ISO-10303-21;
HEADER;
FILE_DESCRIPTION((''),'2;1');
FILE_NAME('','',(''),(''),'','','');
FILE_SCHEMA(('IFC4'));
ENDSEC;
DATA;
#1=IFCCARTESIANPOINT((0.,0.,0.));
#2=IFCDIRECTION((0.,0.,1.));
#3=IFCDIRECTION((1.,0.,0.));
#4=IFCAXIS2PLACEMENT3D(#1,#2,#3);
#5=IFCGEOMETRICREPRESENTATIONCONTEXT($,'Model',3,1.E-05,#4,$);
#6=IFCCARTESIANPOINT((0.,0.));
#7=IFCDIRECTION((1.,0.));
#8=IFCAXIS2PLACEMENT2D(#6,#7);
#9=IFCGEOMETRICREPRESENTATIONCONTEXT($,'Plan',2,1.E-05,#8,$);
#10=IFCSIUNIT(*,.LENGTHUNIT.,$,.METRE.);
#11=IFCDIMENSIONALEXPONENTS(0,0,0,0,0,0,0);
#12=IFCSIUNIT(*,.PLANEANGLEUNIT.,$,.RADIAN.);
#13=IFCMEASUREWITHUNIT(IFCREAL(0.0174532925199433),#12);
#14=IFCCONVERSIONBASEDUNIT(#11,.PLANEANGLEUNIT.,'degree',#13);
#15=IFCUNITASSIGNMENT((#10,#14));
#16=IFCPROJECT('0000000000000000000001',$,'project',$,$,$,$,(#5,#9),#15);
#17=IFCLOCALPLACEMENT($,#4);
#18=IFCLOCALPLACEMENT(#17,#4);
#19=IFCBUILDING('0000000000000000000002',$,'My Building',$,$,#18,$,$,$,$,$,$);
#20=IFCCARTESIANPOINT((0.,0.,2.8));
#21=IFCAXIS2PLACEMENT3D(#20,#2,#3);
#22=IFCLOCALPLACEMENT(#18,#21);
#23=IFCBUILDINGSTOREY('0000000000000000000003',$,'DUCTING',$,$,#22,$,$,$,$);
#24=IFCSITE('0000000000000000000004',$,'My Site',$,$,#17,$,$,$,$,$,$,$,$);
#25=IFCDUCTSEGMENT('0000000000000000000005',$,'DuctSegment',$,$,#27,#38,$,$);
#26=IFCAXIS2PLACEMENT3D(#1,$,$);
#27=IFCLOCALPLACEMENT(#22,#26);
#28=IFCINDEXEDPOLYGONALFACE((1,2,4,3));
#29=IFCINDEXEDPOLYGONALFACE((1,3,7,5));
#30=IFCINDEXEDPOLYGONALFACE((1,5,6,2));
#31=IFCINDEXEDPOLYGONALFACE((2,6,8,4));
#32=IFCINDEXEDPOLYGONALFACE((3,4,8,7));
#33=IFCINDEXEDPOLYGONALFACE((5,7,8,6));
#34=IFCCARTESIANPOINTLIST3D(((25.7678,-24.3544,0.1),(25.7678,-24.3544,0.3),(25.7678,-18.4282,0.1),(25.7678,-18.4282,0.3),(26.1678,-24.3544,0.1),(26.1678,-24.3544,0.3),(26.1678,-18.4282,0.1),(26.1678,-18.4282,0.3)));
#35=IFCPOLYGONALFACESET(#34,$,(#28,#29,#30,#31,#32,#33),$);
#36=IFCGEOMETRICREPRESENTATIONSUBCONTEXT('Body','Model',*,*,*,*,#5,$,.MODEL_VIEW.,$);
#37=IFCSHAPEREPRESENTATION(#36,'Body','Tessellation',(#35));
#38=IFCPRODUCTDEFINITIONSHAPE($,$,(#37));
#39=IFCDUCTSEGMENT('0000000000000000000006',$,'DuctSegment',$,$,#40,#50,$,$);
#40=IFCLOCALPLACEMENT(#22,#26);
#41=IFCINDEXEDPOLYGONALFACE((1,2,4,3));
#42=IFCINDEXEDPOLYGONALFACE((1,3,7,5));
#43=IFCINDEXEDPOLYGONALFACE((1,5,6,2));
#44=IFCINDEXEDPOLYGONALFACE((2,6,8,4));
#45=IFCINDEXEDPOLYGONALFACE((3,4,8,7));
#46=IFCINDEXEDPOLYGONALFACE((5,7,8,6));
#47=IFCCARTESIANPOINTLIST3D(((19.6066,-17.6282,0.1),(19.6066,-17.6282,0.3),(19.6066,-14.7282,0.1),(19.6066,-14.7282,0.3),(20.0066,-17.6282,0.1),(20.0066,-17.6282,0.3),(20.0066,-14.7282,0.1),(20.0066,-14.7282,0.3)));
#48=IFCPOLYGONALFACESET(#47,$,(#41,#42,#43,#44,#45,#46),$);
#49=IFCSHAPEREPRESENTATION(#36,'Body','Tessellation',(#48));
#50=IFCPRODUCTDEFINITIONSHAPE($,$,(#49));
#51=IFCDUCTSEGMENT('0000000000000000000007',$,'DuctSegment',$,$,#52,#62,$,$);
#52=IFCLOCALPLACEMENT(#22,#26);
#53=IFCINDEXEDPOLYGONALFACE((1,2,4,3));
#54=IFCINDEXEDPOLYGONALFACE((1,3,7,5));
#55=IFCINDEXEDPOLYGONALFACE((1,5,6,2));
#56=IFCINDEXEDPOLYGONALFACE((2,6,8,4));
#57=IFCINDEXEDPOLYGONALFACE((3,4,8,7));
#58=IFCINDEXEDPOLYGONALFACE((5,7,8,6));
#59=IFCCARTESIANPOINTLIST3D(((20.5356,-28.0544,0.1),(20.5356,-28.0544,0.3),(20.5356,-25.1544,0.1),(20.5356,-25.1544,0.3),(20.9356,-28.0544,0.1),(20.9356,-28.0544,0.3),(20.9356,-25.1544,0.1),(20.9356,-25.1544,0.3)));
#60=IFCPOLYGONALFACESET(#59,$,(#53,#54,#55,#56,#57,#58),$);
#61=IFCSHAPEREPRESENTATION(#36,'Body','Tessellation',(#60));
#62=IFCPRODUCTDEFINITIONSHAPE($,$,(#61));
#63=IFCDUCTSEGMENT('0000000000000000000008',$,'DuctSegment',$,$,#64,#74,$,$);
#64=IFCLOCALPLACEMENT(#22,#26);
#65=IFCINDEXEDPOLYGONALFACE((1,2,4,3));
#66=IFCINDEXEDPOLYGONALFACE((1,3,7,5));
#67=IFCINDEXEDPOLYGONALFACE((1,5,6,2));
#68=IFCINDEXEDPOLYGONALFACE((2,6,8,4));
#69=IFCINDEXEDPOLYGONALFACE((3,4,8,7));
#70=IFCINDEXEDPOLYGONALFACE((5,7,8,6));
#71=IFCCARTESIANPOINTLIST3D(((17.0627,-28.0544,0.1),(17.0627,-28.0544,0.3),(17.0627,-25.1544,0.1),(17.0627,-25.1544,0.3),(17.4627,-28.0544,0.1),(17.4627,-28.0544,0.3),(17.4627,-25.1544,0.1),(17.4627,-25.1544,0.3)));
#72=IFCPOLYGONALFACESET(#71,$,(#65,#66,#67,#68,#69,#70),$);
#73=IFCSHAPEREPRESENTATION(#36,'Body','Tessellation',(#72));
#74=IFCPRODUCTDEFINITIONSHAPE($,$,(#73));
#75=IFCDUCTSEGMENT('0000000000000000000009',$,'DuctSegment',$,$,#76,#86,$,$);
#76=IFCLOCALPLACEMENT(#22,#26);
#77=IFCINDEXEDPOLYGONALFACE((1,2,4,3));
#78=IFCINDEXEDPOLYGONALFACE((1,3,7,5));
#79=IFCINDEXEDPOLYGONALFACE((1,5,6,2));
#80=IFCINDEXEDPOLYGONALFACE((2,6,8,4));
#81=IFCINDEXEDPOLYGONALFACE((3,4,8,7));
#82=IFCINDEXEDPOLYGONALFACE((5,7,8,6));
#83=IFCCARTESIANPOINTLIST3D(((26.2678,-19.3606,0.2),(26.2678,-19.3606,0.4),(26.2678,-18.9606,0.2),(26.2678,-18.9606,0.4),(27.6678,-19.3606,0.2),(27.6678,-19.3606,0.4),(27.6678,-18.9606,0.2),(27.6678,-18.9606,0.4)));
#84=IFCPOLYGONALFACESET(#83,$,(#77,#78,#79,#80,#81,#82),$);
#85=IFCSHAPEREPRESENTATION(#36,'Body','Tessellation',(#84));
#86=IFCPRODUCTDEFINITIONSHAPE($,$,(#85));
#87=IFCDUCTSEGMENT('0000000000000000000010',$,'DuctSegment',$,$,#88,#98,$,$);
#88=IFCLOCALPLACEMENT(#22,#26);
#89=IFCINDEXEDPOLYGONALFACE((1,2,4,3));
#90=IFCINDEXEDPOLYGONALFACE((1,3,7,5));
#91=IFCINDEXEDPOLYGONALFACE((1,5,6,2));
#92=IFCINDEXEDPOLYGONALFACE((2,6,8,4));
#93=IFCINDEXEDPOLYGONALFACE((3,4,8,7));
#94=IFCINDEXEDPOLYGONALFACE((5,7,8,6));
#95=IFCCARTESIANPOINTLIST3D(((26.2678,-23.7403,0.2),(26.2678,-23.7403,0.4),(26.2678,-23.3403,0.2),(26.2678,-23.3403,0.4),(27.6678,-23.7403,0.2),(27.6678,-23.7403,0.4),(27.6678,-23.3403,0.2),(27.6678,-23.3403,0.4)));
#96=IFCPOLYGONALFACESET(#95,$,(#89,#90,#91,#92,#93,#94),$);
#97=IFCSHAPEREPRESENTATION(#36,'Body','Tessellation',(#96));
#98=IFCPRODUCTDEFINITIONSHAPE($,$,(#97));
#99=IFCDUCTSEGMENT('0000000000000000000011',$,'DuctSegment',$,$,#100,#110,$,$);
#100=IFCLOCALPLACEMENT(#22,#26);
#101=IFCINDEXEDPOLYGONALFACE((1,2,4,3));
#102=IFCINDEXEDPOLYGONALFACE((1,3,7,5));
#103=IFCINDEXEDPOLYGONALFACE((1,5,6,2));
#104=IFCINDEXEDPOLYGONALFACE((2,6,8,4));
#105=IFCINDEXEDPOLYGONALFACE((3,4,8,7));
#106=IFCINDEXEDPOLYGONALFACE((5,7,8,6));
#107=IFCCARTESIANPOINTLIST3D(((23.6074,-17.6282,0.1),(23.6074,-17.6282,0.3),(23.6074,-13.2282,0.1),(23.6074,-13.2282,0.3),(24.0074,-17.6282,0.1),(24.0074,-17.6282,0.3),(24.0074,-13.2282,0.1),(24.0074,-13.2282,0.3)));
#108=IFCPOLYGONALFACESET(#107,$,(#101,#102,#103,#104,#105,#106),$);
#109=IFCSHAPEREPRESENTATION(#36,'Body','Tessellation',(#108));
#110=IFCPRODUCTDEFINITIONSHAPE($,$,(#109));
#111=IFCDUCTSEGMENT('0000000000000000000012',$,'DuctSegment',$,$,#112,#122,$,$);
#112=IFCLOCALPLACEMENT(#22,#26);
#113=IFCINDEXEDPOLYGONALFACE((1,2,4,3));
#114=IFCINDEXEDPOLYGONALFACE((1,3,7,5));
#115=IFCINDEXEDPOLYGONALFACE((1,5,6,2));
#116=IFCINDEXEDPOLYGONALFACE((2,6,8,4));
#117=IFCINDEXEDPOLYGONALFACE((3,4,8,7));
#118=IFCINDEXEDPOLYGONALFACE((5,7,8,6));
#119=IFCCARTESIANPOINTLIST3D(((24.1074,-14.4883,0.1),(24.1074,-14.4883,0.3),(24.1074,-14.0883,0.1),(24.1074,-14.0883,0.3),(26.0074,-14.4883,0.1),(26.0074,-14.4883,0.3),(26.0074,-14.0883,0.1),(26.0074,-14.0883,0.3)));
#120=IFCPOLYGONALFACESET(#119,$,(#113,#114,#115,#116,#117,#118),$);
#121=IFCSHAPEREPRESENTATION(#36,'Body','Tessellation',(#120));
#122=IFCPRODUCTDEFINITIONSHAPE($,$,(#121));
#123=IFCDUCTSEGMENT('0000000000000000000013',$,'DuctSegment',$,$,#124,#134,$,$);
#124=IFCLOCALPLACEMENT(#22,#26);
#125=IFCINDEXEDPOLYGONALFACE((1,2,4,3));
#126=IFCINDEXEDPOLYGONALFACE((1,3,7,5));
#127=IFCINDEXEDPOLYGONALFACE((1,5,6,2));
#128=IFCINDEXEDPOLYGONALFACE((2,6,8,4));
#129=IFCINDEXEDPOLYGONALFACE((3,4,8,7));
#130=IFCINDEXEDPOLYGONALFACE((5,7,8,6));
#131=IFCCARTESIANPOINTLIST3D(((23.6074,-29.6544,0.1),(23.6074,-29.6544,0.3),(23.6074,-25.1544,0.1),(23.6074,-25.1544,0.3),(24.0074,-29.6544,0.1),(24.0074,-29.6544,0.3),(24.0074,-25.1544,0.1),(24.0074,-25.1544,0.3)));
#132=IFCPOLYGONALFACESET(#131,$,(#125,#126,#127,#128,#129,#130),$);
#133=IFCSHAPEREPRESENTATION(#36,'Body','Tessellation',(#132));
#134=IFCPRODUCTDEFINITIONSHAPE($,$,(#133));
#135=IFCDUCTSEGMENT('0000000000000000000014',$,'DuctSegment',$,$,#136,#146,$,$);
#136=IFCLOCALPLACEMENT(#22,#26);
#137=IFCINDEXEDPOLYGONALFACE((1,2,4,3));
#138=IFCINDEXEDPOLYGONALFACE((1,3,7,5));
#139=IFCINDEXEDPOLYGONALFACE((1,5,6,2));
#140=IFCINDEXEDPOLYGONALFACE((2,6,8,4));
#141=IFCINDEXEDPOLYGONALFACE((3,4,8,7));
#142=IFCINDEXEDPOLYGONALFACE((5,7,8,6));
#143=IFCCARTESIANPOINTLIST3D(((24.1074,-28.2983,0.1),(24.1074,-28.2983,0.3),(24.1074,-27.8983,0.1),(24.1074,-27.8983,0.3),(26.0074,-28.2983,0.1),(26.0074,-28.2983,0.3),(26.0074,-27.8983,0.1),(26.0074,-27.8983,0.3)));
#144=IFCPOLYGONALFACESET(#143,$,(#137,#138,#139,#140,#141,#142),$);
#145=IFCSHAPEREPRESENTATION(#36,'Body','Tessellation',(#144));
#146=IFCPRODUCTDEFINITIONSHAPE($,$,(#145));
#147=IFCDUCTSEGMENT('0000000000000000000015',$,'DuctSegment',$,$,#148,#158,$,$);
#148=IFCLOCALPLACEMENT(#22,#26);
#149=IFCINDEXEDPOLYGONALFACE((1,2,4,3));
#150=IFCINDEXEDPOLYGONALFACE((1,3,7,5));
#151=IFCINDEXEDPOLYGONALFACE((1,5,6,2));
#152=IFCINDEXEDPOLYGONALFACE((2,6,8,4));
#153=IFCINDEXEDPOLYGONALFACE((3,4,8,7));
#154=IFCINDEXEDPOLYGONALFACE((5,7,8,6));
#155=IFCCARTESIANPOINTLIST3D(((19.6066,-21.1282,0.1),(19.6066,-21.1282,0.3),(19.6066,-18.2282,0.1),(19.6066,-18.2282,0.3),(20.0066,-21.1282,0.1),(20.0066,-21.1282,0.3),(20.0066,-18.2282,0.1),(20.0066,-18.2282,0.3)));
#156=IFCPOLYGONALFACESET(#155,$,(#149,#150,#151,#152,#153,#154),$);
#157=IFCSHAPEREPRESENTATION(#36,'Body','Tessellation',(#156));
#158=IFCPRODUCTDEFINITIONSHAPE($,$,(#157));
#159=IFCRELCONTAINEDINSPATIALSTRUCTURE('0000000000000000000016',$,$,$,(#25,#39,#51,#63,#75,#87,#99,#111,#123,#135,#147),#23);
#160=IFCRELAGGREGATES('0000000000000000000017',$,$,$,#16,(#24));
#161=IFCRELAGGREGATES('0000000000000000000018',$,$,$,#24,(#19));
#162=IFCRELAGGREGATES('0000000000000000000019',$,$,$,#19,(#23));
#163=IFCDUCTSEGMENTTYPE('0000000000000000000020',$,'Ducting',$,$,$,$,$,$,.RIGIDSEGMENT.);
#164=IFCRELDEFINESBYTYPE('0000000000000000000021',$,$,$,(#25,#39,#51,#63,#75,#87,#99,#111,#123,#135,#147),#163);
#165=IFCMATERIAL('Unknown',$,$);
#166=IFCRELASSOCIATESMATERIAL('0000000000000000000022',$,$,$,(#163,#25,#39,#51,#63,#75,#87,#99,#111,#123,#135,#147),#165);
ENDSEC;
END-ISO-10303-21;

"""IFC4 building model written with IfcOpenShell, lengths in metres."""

from ifc_helpers import new_model, entity, si_unit, converted_unit, frame, origin_with_axes, origin_2d_with_axis, place, context, subcontext, project, spatial, rectangle, extrude, material, material_profile, profile_set, profile_usage, type_object, element, save


model = new_model("IFC4")

# Units and contexts
model_context = context("Model", 3, precision=1e-05, world=origin_with_axes())
plan_context = context("Plan", 2, precision=1e-05, world=origin_2d_with_axis())
body_context = subcontext(model_context, "Body", "Model", "MODEL_VIEW")
ifc_project = project(units=[si_unit("LENGTHUNIT", "METRE"), converted_unit("PLANEANGLEUNIT", "degree", entity("IfcReal", 0.0174532925199433), si_unit("PLANEANGLEUNIT", "RADIAN"), dimensions=[0, 0, 0, 0, 0, 0, 0])], contexts=[model_context, plan_context])

# Site, building, storey
site_placement = place(None, origin_with_axes())
site = spatial("IfcSite", under=ifc_project, at=site_placement, Name="My Site")
building_placement = place(site_placement, origin_with_axes())
building = spatial("IfcBuilding", under=site, at=building_placement, Name="My Building")
storey_placement = place(building_placement, frame((0.0, 0.0, 2.8), z_axis=(0.0, 0.0, 1.0), x_axis=(1.0, 0.0, 0.0)))
storey = spatial("IfcBuildingStorey", under=building, at=storey_placement, Name="DUCTING")

# Duct segments
ifc_material = material(Name="Unknown")
ifc_material_profile_1 = material_profile(ifc_material, rectangle(XDim=0.4, YDim=0.2))
ifc_profile_set_1 = profile_set([ifc_material_profile_1])
ifc_profile_usage_1 = profile_usage(ifc_profile_set_1, cardinal=5)
duct_segment_type = type_object("IfcDuctSegmentType", Name="Ducting", PredefinedType="RIGIDSEGMENT", material=ifc_profile_set_1)
duct_segment_1_placement = place(storey_placement, frame((25.9678, -18.4282, 0.2), z_axis=(0.0, -1.0, 0.0), x_axis=(1.0, 0.0, 0.0)))
element("IfcDuctSegment", 1, at=duct_segment_1_placement, inside=storey, type_object=duct_segment_type, material=ifc_profile_usage_1, Name="DuctSegment", context=body_context, shape_type="SweptSolid", body=[
    extrude(rectangle(XDim=0.4, YDim=0.2), origin_with_axes(), (0.0, 0.0, 1.0), 5.9263),
])
ifc_profile_usage_2 = profile_usage(ifc_profile_set_1, cardinal=5)
duct_segment_2_placement = place(storey_placement, frame((19.8066, -14.7282, 0.2), z_axis=(0.0, -1.0, 0.0), x_axis=(1.0, 0.0, 0.0)))
element("IfcDuctSegment", 2, at=duct_segment_2_placement, inside=storey, type_object=duct_segment_type, material=ifc_profile_usage_2, Name="DuctSegment", context=body_context, shape_type="SweptSolid", body=[
    extrude(rectangle(XDim=0.4, YDim=0.2), origin_with_axes(), (0.0, 0.0, 1.0), 2.9),
])
ifc_profile_usage_3 = profile_usage(ifc_profile_set_1, cardinal=5)
duct_segment_3_placement = place(storey_placement, frame((20.7356, -28.0544, 0.2), z_axis=(0.000001, 1.0, 0.0), x_axis=(-1.0, 0.000001, 0.0)))
element("IfcDuctSegment", 3, at=duct_segment_3_placement, inside=storey, type_object=duct_segment_type, material=ifc_profile_usage_3, Name="DuctSegment", context=body_context, shape_type="SweptSolid", body=[
    extrude(rectangle(XDim=0.4, YDim=0.2), origin_with_axes(), (0.0, 0.0, 1.0), 2.9),
])
ifc_profile_usage_4 = profile_usage(ifc_profile_set_1, cardinal=5)
duct_segment_4_placement = place(storey_placement, frame((17.2627, -28.0544, 0.2), z_axis=(0.000001, 1.0, 0.0), x_axis=(-1.0, 0.000001, 0.0)))
element("IfcDuctSegment", 4, at=duct_segment_4_placement, inside=storey, type_object=duct_segment_type, material=ifc_profile_usage_4, Name="DuctSegment", context=body_context, shape_type="SweptSolid", body=[
    extrude(rectangle(XDim=0.4, YDim=0.2), origin_with_axes(), (0.0, 0.0, 1.0), 2.9),
])
ifc_profile_usage_5 = profile_usage(ifc_profile_set_1, cardinal=5)
duct_segment_5_placement = place(storey_placement, frame((26.2678, -19.1606, 0.3), z_axis=(1.0, 0.0, 0.0), x_axis=(0.0, 1.0, 0.0)))
element("IfcDuctSegment", 5, at=duct_segment_5_placement, inside=storey, type_object=duct_segment_type, material=ifc_profile_usage_5, Name="DuctSegment", context=body_context, shape_type="SweptSolid", body=[
    extrude(rectangle(XDim=0.4, YDim=0.2), origin_with_axes(), (0.0, 0.0, 1.0), 1.4),
])
ifc_profile_usage_6 = profile_usage(ifc_profile_set_1, cardinal=5)
duct_segment_6_placement = place(storey_placement, frame((26.2678, -23.5403, 0.3), z_axis=(1.0, 0.0, 0.0), x_axis=(0.0, 1.0, 0.0)))
element("IfcDuctSegment", 6, at=duct_segment_6_placement, inside=storey, type_object=duct_segment_type, material=ifc_profile_usage_6, Name="DuctSegment", context=body_context, shape_type="SweptSolid", body=[
    extrude(rectangle(XDim=0.4, YDim=0.2), origin_with_axes(), (0.0, 0.0, 1.0), 1.4),
])
ifc_profile_usage_7 = profile_usage(ifc_profile_set_1, cardinal=5)
duct_segment_7_placement = place(storey_placement, frame((23.8074, -17.6282, 0.2), z_axis=(0.0, 1.0, -0.000002), x_axis=(-1.0, 0.0, 0.0)))
element("IfcDuctSegment", 7, at=duct_segment_7_placement, inside=storey, type_object=duct_segment_type, material=ifc_profile_usage_7, Name="DuctSegment", context=body_context, shape_type="SweptSolid", body=[
    extrude(rectangle(XDim=0.4, YDim=0.2), origin_with_axes(), (0.0, 0.0, 1.0), 4.4),
])
ifc_profile_usage_8 = profile_usage(ifc_profile_set_1, cardinal=5)
duct_segment_8_placement = place(storey_placement, frame((24.1074, -14.2883, 0.2), z_axis=(1.0, 0.0, 0.0), x_axis=(0.0, 1.0, 0.0)))
element("IfcDuctSegment", 8, at=duct_segment_8_placement, inside=storey, type_object=duct_segment_type, material=ifc_profile_usage_8, Name="DuctSegment", context=body_context, shape_type="SweptSolid", body=[
    extrude(rectangle(XDim=0.4, YDim=0.2), origin_with_axes(), (0.0, 0.0, 1.0), 1.9),
])
ifc_profile_usage_9 = profile_usage(ifc_profile_set_1, cardinal=5)
duct_segment_9_placement = place(storey_placement, frame((23.8074, -25.1544, 0.2), z_axis=(0.0, -1.0, 0.0), x_axis=(1.0, 0.0, 0.0)))
element("IfcDuctSegment", 9, at=duct_segment_9_placement, inside=storey, type_object=duct_segment_type, material=ifc_profile_usage_9, Name="DuctSegment", context=body_context, shape_type="SweptSolid", body=[
    extrude(rectangle(XDim=0.4, YDim=0.2), origin_with_axes(), (0.0, 0.0, 1.0), 4.5),
])
ifc_profile_usage_10 = profile_usage(ifc_profile_set_1, cardinal=5)
duct_segment_10_placement = place(storey_placement, frame((24.1074, -28.0983, 0.2), z_axis=(1.0, 0.0, 0.0), x_axis=(0.0, 1.0, 0.0)))
element("IfcDuctSegment", 10, at=duct_segment_10_placement, inside=storey, type_object=duct_segment_type, material=ifc_profile_usage_10, Name="DuctSegment", context=body_context, shape_type="SweptSolid", body=[
    extrude(rectangle(XDim=0.4, YDim=0.2), origin_with_axes(), (0.0, 0.0, 1.0), 1.9),
])
ifc_profile_usage_11 = profile_usage(ifc_profile_set_1, cardinal=5)
duct_segment_11_placement = place(storey_placement, frame((19.8066, -21.1282, 0.2), z_axis=(0.000001, 1.0, 0.0), x_axis=(-1.0, 0.000001, 0.0)))
element("IfcDuctSegment", 11, at=duct_segment_11_placement, inside=storey, type_object=duct_segment_type, material=ifc_profile_usage_11, Name="DuctSegment", context=body_context, shape_type="SweptSolid", body=[
    extrude(rectangle(XDim=0.4, YDim=0.2), origin_with_axes(), (0.0, 0.0, 1.0), 2.9),
])

save(model, "model.ifc")
